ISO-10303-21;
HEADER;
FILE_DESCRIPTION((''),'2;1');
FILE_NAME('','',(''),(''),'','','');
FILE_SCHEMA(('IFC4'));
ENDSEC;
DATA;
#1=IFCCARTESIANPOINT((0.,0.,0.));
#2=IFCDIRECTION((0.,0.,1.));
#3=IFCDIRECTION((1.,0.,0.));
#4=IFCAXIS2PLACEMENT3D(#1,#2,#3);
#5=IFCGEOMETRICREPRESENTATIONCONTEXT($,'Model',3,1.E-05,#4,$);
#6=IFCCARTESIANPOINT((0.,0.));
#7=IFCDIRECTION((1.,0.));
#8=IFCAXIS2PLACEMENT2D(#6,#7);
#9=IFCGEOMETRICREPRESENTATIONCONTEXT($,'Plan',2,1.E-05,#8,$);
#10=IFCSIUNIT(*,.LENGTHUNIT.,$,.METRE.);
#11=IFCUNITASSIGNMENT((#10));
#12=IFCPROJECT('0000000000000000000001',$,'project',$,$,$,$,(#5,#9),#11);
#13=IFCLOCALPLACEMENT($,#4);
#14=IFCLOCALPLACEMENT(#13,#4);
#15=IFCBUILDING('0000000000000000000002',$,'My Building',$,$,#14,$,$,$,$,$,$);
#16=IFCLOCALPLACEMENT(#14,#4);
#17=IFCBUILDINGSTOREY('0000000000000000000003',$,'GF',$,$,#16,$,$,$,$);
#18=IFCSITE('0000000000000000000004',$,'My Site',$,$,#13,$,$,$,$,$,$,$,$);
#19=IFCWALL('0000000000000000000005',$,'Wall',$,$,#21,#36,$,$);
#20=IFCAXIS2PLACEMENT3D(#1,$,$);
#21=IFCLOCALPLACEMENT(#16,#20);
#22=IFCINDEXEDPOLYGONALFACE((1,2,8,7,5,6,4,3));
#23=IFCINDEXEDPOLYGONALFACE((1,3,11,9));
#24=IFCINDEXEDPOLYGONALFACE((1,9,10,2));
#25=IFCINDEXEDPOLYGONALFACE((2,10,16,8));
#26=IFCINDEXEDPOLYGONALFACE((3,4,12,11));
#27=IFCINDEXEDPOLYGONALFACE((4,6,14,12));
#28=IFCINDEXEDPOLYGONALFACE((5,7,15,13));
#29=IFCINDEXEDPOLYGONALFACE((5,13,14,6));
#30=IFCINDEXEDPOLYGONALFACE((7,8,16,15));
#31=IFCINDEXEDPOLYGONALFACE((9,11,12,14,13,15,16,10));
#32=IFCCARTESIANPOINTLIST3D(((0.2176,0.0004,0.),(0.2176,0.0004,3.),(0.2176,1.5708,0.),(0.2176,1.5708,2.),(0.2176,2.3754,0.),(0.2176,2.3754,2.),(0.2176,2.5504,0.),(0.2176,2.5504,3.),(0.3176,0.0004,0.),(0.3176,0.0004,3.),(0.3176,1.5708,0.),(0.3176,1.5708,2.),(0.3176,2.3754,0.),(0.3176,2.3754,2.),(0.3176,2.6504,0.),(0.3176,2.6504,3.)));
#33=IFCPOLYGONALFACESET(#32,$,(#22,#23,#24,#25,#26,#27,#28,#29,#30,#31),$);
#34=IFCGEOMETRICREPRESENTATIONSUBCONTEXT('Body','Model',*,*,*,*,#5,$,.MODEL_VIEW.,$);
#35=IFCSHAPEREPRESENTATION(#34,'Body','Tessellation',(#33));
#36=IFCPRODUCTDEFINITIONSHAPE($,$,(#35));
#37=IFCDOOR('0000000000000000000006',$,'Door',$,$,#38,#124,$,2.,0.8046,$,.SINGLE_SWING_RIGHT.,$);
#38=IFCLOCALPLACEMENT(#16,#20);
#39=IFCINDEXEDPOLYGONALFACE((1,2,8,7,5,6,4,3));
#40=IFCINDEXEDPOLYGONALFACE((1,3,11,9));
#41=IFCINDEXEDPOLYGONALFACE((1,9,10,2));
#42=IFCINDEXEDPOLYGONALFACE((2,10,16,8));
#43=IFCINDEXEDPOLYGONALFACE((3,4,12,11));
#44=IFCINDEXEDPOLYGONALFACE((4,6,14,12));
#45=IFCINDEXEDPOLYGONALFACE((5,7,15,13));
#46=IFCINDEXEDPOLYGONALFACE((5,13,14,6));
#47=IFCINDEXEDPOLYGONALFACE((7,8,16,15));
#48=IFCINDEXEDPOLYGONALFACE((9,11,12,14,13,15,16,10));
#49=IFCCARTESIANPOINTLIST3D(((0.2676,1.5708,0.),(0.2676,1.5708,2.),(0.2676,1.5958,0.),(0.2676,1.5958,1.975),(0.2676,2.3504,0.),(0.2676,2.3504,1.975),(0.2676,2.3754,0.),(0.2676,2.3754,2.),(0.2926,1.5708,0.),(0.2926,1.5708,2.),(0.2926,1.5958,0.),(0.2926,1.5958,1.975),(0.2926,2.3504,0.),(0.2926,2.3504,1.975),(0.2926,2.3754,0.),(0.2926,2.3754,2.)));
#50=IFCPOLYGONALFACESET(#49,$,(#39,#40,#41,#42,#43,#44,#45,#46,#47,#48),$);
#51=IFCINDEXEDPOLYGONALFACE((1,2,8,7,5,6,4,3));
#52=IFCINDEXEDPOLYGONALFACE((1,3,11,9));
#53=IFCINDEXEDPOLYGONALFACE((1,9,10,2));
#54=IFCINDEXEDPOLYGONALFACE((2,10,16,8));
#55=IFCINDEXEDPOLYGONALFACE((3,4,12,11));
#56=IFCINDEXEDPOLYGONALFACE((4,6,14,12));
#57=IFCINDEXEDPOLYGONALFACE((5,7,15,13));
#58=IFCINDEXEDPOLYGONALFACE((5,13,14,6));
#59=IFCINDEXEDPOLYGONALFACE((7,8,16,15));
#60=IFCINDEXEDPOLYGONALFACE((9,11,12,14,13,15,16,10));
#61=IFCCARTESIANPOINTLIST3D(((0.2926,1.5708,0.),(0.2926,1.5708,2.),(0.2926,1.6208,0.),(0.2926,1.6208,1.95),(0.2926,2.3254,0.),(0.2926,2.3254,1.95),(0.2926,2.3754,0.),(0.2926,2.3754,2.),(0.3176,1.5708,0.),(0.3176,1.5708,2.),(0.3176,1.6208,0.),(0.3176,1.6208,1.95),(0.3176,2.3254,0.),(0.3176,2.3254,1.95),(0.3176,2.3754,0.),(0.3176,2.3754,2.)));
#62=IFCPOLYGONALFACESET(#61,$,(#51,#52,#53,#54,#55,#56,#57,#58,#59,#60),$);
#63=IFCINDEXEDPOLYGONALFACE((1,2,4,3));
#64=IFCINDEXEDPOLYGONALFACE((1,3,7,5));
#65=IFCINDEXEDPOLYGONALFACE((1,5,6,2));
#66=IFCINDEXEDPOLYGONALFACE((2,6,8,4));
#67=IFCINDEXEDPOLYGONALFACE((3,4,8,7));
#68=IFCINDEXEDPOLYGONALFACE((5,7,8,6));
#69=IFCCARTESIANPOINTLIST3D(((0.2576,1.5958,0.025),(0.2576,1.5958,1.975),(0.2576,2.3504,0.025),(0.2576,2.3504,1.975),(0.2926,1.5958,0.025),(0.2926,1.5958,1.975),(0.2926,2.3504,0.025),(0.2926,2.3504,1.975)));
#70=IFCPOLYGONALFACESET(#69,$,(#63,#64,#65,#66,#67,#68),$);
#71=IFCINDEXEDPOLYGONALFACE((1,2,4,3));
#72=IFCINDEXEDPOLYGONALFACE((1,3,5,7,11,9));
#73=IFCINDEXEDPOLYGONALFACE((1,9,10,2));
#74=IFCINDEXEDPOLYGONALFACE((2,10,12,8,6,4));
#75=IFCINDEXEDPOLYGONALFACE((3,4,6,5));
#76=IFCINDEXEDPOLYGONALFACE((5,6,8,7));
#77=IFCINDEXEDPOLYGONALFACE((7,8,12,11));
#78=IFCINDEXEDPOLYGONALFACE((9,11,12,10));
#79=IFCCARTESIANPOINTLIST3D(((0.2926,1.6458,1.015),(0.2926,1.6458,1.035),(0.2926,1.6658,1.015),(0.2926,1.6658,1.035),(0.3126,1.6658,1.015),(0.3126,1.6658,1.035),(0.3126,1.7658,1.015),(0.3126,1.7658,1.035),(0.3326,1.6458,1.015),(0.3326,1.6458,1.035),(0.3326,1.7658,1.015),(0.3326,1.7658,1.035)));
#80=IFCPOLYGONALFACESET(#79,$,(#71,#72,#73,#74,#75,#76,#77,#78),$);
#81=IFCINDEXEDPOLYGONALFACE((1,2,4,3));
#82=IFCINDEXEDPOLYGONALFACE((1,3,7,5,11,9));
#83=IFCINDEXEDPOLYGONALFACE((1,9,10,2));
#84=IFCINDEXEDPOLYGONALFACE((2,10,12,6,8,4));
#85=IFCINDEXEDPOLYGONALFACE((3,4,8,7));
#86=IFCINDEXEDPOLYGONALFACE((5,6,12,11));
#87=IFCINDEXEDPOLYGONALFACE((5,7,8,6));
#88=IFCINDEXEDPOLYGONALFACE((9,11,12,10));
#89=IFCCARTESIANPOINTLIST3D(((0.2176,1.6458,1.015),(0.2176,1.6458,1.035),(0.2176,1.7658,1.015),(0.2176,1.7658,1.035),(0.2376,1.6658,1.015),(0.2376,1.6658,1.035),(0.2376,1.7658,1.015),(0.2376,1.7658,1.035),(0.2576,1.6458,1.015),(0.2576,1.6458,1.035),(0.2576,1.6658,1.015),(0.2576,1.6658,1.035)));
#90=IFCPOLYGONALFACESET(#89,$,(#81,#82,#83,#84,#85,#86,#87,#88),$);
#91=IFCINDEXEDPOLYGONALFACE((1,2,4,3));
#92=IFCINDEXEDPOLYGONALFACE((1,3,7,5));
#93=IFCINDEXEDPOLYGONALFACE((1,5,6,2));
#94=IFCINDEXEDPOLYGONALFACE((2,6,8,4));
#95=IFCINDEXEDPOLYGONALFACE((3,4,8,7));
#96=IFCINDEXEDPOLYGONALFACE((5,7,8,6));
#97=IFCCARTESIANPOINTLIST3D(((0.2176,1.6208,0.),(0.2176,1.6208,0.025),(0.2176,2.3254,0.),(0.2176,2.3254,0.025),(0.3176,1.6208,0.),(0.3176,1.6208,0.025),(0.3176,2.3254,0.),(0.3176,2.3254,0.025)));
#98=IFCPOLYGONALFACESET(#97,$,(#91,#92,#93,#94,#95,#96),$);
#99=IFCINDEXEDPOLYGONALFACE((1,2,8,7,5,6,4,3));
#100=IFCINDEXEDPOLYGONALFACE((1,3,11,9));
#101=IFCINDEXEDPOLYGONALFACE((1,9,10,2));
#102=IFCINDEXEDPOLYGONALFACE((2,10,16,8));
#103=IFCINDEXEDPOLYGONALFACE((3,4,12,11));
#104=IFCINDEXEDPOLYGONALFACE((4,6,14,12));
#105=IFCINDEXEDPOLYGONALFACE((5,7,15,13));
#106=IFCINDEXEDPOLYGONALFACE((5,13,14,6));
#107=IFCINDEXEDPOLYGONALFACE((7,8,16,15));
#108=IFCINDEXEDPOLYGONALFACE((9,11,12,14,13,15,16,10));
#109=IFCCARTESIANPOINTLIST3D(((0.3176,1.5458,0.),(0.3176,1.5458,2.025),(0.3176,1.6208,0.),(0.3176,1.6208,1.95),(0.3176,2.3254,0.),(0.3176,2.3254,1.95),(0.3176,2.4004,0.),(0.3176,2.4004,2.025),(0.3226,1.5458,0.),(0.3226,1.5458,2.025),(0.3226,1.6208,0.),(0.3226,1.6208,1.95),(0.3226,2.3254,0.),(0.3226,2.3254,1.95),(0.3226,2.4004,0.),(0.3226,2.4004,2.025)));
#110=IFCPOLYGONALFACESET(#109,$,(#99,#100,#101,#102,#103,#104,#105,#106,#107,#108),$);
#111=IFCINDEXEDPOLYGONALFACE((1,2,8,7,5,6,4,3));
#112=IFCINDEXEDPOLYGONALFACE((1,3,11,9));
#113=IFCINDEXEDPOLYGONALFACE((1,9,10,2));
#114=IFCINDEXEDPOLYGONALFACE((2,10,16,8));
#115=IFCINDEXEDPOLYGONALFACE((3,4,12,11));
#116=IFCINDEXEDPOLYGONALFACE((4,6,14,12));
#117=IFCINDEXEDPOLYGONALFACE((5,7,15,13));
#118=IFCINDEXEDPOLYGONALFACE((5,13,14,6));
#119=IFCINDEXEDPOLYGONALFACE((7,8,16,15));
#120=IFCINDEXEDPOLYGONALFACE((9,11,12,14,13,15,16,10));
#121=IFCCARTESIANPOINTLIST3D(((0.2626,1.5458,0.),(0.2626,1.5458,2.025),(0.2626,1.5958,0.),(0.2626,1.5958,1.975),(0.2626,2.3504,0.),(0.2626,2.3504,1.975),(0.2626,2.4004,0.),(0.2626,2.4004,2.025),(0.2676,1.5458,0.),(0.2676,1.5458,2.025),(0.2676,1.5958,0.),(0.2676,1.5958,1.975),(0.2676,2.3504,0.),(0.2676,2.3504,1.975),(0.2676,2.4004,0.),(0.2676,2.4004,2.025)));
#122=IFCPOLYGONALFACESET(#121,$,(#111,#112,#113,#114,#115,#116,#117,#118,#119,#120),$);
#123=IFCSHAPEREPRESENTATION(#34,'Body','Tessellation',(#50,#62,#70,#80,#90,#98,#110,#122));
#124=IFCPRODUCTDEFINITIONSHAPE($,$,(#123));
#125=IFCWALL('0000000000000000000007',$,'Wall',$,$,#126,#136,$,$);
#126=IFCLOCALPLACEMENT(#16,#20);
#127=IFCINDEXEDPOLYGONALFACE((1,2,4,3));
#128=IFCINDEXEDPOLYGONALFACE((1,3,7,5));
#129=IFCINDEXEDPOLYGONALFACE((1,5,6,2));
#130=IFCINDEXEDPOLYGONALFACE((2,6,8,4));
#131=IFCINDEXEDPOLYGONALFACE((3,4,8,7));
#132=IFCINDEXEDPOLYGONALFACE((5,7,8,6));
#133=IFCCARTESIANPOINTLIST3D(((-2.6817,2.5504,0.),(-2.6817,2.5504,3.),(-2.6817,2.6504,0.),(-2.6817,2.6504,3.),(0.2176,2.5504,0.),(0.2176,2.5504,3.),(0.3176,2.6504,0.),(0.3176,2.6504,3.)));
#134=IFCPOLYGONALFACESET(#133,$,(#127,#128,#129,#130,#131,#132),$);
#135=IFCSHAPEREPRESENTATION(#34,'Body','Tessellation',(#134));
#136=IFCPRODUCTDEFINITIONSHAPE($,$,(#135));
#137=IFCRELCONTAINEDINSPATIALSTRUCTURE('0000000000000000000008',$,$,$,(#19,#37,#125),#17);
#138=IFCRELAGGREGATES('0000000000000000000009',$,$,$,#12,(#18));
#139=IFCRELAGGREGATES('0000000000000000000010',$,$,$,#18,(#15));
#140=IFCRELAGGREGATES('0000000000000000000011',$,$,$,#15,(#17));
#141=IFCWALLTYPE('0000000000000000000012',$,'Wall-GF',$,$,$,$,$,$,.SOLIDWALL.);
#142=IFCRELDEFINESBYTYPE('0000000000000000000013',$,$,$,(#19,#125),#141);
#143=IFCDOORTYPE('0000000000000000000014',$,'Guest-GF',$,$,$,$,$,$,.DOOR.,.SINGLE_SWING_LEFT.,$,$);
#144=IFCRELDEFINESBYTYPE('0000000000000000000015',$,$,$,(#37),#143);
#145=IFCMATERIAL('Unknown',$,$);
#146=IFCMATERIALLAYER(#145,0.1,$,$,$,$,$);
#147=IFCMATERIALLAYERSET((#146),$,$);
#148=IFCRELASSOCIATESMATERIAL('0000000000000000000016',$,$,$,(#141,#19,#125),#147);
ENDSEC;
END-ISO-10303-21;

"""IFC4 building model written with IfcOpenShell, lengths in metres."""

from ifc_helpers import new_model, entity, si_unit, frame, origin_with_axes, origin_2d_with_axis, place, context, subcontext, project, spatial, line, indexed_curve, outline, extrude, shape, source, transform, mapped, material, layer, layer_set, layer_usage, type_object, type_shapes, element, fill, save


model = new_model("IFC4")

# Units and contexts
model_context = context("Model", 3, precision=1e-05, world=origin_with_axes())
plan_context = context("Plan", 2, precision=1e-05, world=origin_2d_with_axis())
body_context_1 = subcontext(model_context, "Body", "Model", "MODEL_VIEW")
body_context_2 = subcontext(plan_context, "Body", "Plan", "PLAN_VIEW")
ifc_project = project(units=[si_unit("LENGTHUNIT", "METRE")], contexts=[model_context, plan_context])

# Site, building, storey
site_placement = place(None, origin_with_axes())
site = spatial("IfcSite", under=ifc_project, at=site_placement, Name="My Site")
building_placement = place(site_placement, origin_with_axes())
building = spatial("IfcBuilding", under=site, at=building_placement, Name="My Building")
storey_placement = place(building_placement, origin_with_axes())
storey = spatial("IfcBuildingStorey", under=building, at=storey_placement, Name="GF")

# Shared definitions
ifc_material = material(Name="Unknown")

# Shared definitions
ifc_layer_1 = layer(ifc_material, 0.1)
ifc_layer_set_1 = layer_set([ifc_layer_1])
wall_type = type_object("IfcWallType", Name="Wall-GF", PredefinedType="SOLIDWALL", material=ifc_layer_set_1)

# Wall, opening, door
ifc_layer_usage_1 = layer_usage(ifc_layer_set_1, "AXIS2", "POSITIVE", 0.0)
wall_1_placement = place(storey_placement, frame((0.3176, 0.0004, 0.0), z_axis=(0.0, 0.0, 1.0), x_axis=(0.0, 1.0, 0.0)))
wall_1 = element("IfcWall", 1, at=wall_1_placement, inside=storey, type_object=wall_type, material=ifc_layer_usage_1, Name="Wall", context=body_context_1, shape_type="SweptSolid", body=[
    extrude(outline(indexed_curve([(0.0, 0.0), (0.0, 0.1), (2.55, 0.1), (2.65, 0.0)], segments=[line(1, 2, 3, 4, 1)])), origin_with_axes(), (0.0, 0.0, 1.0), 3.0),
])
shared_shape_1 = source(origin_with_axes(), body_context_1, "Body", "SweptSolid", [
    extrude(outline(indexed_curve([(0.0, 0.0), (0.8046, 0.0), (0.8046, 2.0), (0.0, 2.0)], segments=[line(1, 2, 3, 4, 1)])), frame((0.0, -0.6, 0.0), z_axis=(0.0, -1.0, 0.0), x_axis=(1.0, 0.0, 0.0)), (0.0, 0.0, -1.0), 1.2),
])
opening_1_placement = place(wall_1_placement, frame((1.5705, 0.0, 0.0), z_axis=(0.0, 0.0, 1.0), x_axis=(1.0, 0.0, 0.0)))
opening_1 = element("IfcOpeningElement", 2, at=opening_1_placement, cuts=wall_1, PredefinedType="OPENING", context=body_context_1, shape_type="MappedRepresentation", body=[
    mapped(shared_shape_1, transform((0.0, 0.0, 0.0), x_axis=(1.0, 0.0, 0.0), y_axis=(0.0, 1.0, 0.0), z_axis=(0.0, 0.0, 1.0), scale=1.0)),
])
door_type_1 = type_object("IfcDoorType", Name="Guest-GF", OperationType="SINGLE_SWING_LEFT", PredefinedType="DOOR")
shared_shape_2 = source(origin_with_axes(), body_context_1, "Body", "SweptSolid", [
    extrude(outline(indexed_curve([(0.0, 0.0), (0.0, 2.0), (0.8046, 2.0), (0.8046, 0.0), (0.7796, 0.0), (0.7796, 1.975), (0.025, 1.975), (0.025, 0.0)], segments=[line(1, 2, 3, 4, 5, 6, 7, 8, 1)])), frame((0.0, 0.025, 0.0), z_axis=(0.0, -1.0, 0.0), x_axis=(1.0, 0.0, 0.0)), (0.0, 0.0, -1.0), 0.025),
    extrude(outline(indexed_curve([(0.0, 0.0), (0.0, 2.0), (0.8046, 2.0), (0.8046, 0.0), (0.7546, 0.0), (0.7546, 1.95), (0.05, 1.95), (0.05, 0.0)], segments=[line(1, 2, 3, 4, 5, 6, 7, 8, 1)])), frame((0.0, 0.0, 0.0), z_axis=(0.0, -1.0, 0.0), x_axis=(1.0, 0.0, 0.0)), (0.0, 0.0, -1.0), 0.025),
    extrude(outline(indexed_curve([(0.0, 0.0), (0.7546, 0.0), (0.7546, 0.035), (0.0, 0.035)], segments=[line(1, 2, 3, 4, 1)])), frame((0.025, 0.025, 0.025), z_axis=(0.0, 0.0, 1.0), x_axis=(1.0, 0.0, 0.0)), (0.0, 0.0, 1.0), 1.95),
    extrude(outline(indexed_curve([(0.0, 0.0), (0.0, -0.04), (0.12, -0.04), (0.12, -0.02), (0.02, -0.02), (0.02, 0.0)], segments=[line(1, 2, 3, 4, 5, 6, 1)])), frame((0.075, 0.025, 1.015), z_axis=(0.0, 0.0, 1.0), x_axis=(1.0, 0.0, 0.0)), (0.0, 0.0, 1.0), 0.02),
    extrude(outline(indexed_curve([(0.0, 0.0), (0.0, 0.04), (0.12, 0.04), (0.12, 0.02), (0.02, 0.02), (0.02, 0.0)], segments=[line(1, 2, 3, 4, 5, 6, 1)])), frame((0.075, 0.06, 1.015), z_axis=(0.0, 0.0, 1.0), x_axis=(1.0, 0.0, 0.0)), (0.0, 0.0, 1.0), 0.02),
    extrude(outline(indexed_curve([(0.0, 0.0), (0.7046, 0.0), (0.7046, 0.1), (0.0, 0.1)], segments=[line(1, 2, 3, 4, 1)])), frame((0.05, 0.0, 0.0), z_axis=(0.0, 0.0, 1.0), x_axis=(1.0, 0.0, 0.0)), (0.0, 0.0, 1.0), 0.025),
    extrude(outline(indexed_curve([(0.0, 0.0), (0.0, 2.025), (0.8546, 2.025), (0.8546, 0.0), (0.7796, 0.0), (0.7796, 1.95), (0.075, 1.95), (0.075, 0.0)], segments=[line(1, 2, 3, 4, 5, 6, 7, 8, 1)])), frame((-0.025, -0.005, 0.0), z_axis=(0.0, -1.0, 0.0), x_axis=(1.0, 0.0, 0.0)), (0.0, 0.0, -1.0), 0.005),
    extrude(outline(indexed_curve([(0.0, 0.0), (0.0, 2.025), (0.8546, 2.025), (0.8546, 0.0), (0.8046, 0.0), (0.8046, 1.975), (0.05, 1.975), (0.05, 0.0)], segments=[line(1, 2, 3, 4, 5, 6, 7, 8, 1)])), frame((-0.025, 0.05, 0.0), z_axis=(0.0, -1.0, 0.0), x_axis=(1.0, 0.0, 0.0)), (0.0, 0.0, -1.0), 0.005),
])
shared_shape_3 = source(origin_with_axes(), body_context_2, "Body", "Curve2D", [
    entity("IfcIndexedPolyCurve", entity("IfcCartesianPointList2D", [[0.0, 0.0], [0.0, 0.05], [0.025, 0.05], [0.025, 0.025], [0.05, 0.025], [0.05, 0.0]]), [entity("IfcLineIndex", [1, 2, 3, 4, 5, 6, 1])]),
    entity("IfcIndexedPolyCurve", entity("IfcCartesianPointList2D", [[0.8046, 0.0], [0.8046, 0.05], [0.7796, 0.05], [0.7796, 0.025], [0.7546, 0.025], [0.7546, 0.0]]), [entity("IfcLineIndex", [1, 2, 3, 4, 5, 6, 1])]),
    entity("IfcTrimmedCurve", entity("IfcEllipse", entity("IfcAxis2Placement2D", entity("IfcCartesianPoint", [0.7446, 0.05]), entity("IfcDirection", [1.0, 0.0])), 0.7196, 0.7546), [entity("IfcCartesianPoint", [0.7446, 0.8046])], [entity("IfcCartesianPoint", [0.025, 0.05])], True, "CARTESIAN"),
    entity("IfcIndexedPolyCurve", entity("IfcCartesianPointList2D", [[0.7796, 0.05], [0.7446, 0.05], [0.7446, 0.8046], [0.7796, 0.8046]]), [entity("IfcLineIndex", [1, 2, 3, 4, 1])]),
])
type_shapes(door_type_1, [shared_shape_2, shared_shape_3])
door_1_placement = place(opening_1_placement, frame((0.0, 0.0, 0.0), z_axis=(0.0, 0.0, 1.0), x_axis=(1.0, 0.0, 0.0)))
door_1 = element("IfcDoor", 3, at=door_1_placement, inside=storey, type_object=door_type_1, Name="Door", OperationType="SINGLE_SWING_RIGHT", OverallHeight=2.0, OverallWidth=0.8046, shapes=[
    shape(body_context_1, "Body", "MappedRepresentation", [mapped(shared_shape_2, transform((0.0, 0.0, 0.0), x_axis=(1.0, 0.0, 0.0), y_axis=(0.0, 1.0, 0.0), z_axis=(0.0, 0.0, 1.0), scale=1.0))]),
    shape(body_context_2, "Body", "MappedRepresentation", [mapped(shared_shape_3, transform((0.0, 0.0, 0.0), x_axis=(1.0, 0.0, 0.0), y_axis=(0.0, 1.0, 0.0), z_axis=(0.0, 0.0, 1.0), scale=1.0))]),
])
fill(opening_1, door_1)

# Wall
ifc_layer_usage_2 = layer_usage(ifc_layer_set_1, "AXIS2", "POSITIVE", 0.0)
wall_2_placement = place(storey_placement, frame((0.3176, 2.6504, 0.0), z_axis=(0.0, 0.0, 1.0), x_axis=(-1.0, 0.0, 0.0)))
element("IfcWall", 4, at=wall_2_placement, inside=storey, type_object=wall_type, material=ifc_layer_usage_2, Name="Wall", context=body_context_1, shape_type="SweptSolid", body=[
    extrude(outline(indexed_curve([(0.0, 0.0), (0.1, 0.1), (2.9992, 0.1), (2.9992, 0.0)], segments=[line(1, 2, 3, 4, 1)])), origin_with_axes(), (0.0, 0.0, 1.0), 3.0),
])

save(model, "model.ifc")
